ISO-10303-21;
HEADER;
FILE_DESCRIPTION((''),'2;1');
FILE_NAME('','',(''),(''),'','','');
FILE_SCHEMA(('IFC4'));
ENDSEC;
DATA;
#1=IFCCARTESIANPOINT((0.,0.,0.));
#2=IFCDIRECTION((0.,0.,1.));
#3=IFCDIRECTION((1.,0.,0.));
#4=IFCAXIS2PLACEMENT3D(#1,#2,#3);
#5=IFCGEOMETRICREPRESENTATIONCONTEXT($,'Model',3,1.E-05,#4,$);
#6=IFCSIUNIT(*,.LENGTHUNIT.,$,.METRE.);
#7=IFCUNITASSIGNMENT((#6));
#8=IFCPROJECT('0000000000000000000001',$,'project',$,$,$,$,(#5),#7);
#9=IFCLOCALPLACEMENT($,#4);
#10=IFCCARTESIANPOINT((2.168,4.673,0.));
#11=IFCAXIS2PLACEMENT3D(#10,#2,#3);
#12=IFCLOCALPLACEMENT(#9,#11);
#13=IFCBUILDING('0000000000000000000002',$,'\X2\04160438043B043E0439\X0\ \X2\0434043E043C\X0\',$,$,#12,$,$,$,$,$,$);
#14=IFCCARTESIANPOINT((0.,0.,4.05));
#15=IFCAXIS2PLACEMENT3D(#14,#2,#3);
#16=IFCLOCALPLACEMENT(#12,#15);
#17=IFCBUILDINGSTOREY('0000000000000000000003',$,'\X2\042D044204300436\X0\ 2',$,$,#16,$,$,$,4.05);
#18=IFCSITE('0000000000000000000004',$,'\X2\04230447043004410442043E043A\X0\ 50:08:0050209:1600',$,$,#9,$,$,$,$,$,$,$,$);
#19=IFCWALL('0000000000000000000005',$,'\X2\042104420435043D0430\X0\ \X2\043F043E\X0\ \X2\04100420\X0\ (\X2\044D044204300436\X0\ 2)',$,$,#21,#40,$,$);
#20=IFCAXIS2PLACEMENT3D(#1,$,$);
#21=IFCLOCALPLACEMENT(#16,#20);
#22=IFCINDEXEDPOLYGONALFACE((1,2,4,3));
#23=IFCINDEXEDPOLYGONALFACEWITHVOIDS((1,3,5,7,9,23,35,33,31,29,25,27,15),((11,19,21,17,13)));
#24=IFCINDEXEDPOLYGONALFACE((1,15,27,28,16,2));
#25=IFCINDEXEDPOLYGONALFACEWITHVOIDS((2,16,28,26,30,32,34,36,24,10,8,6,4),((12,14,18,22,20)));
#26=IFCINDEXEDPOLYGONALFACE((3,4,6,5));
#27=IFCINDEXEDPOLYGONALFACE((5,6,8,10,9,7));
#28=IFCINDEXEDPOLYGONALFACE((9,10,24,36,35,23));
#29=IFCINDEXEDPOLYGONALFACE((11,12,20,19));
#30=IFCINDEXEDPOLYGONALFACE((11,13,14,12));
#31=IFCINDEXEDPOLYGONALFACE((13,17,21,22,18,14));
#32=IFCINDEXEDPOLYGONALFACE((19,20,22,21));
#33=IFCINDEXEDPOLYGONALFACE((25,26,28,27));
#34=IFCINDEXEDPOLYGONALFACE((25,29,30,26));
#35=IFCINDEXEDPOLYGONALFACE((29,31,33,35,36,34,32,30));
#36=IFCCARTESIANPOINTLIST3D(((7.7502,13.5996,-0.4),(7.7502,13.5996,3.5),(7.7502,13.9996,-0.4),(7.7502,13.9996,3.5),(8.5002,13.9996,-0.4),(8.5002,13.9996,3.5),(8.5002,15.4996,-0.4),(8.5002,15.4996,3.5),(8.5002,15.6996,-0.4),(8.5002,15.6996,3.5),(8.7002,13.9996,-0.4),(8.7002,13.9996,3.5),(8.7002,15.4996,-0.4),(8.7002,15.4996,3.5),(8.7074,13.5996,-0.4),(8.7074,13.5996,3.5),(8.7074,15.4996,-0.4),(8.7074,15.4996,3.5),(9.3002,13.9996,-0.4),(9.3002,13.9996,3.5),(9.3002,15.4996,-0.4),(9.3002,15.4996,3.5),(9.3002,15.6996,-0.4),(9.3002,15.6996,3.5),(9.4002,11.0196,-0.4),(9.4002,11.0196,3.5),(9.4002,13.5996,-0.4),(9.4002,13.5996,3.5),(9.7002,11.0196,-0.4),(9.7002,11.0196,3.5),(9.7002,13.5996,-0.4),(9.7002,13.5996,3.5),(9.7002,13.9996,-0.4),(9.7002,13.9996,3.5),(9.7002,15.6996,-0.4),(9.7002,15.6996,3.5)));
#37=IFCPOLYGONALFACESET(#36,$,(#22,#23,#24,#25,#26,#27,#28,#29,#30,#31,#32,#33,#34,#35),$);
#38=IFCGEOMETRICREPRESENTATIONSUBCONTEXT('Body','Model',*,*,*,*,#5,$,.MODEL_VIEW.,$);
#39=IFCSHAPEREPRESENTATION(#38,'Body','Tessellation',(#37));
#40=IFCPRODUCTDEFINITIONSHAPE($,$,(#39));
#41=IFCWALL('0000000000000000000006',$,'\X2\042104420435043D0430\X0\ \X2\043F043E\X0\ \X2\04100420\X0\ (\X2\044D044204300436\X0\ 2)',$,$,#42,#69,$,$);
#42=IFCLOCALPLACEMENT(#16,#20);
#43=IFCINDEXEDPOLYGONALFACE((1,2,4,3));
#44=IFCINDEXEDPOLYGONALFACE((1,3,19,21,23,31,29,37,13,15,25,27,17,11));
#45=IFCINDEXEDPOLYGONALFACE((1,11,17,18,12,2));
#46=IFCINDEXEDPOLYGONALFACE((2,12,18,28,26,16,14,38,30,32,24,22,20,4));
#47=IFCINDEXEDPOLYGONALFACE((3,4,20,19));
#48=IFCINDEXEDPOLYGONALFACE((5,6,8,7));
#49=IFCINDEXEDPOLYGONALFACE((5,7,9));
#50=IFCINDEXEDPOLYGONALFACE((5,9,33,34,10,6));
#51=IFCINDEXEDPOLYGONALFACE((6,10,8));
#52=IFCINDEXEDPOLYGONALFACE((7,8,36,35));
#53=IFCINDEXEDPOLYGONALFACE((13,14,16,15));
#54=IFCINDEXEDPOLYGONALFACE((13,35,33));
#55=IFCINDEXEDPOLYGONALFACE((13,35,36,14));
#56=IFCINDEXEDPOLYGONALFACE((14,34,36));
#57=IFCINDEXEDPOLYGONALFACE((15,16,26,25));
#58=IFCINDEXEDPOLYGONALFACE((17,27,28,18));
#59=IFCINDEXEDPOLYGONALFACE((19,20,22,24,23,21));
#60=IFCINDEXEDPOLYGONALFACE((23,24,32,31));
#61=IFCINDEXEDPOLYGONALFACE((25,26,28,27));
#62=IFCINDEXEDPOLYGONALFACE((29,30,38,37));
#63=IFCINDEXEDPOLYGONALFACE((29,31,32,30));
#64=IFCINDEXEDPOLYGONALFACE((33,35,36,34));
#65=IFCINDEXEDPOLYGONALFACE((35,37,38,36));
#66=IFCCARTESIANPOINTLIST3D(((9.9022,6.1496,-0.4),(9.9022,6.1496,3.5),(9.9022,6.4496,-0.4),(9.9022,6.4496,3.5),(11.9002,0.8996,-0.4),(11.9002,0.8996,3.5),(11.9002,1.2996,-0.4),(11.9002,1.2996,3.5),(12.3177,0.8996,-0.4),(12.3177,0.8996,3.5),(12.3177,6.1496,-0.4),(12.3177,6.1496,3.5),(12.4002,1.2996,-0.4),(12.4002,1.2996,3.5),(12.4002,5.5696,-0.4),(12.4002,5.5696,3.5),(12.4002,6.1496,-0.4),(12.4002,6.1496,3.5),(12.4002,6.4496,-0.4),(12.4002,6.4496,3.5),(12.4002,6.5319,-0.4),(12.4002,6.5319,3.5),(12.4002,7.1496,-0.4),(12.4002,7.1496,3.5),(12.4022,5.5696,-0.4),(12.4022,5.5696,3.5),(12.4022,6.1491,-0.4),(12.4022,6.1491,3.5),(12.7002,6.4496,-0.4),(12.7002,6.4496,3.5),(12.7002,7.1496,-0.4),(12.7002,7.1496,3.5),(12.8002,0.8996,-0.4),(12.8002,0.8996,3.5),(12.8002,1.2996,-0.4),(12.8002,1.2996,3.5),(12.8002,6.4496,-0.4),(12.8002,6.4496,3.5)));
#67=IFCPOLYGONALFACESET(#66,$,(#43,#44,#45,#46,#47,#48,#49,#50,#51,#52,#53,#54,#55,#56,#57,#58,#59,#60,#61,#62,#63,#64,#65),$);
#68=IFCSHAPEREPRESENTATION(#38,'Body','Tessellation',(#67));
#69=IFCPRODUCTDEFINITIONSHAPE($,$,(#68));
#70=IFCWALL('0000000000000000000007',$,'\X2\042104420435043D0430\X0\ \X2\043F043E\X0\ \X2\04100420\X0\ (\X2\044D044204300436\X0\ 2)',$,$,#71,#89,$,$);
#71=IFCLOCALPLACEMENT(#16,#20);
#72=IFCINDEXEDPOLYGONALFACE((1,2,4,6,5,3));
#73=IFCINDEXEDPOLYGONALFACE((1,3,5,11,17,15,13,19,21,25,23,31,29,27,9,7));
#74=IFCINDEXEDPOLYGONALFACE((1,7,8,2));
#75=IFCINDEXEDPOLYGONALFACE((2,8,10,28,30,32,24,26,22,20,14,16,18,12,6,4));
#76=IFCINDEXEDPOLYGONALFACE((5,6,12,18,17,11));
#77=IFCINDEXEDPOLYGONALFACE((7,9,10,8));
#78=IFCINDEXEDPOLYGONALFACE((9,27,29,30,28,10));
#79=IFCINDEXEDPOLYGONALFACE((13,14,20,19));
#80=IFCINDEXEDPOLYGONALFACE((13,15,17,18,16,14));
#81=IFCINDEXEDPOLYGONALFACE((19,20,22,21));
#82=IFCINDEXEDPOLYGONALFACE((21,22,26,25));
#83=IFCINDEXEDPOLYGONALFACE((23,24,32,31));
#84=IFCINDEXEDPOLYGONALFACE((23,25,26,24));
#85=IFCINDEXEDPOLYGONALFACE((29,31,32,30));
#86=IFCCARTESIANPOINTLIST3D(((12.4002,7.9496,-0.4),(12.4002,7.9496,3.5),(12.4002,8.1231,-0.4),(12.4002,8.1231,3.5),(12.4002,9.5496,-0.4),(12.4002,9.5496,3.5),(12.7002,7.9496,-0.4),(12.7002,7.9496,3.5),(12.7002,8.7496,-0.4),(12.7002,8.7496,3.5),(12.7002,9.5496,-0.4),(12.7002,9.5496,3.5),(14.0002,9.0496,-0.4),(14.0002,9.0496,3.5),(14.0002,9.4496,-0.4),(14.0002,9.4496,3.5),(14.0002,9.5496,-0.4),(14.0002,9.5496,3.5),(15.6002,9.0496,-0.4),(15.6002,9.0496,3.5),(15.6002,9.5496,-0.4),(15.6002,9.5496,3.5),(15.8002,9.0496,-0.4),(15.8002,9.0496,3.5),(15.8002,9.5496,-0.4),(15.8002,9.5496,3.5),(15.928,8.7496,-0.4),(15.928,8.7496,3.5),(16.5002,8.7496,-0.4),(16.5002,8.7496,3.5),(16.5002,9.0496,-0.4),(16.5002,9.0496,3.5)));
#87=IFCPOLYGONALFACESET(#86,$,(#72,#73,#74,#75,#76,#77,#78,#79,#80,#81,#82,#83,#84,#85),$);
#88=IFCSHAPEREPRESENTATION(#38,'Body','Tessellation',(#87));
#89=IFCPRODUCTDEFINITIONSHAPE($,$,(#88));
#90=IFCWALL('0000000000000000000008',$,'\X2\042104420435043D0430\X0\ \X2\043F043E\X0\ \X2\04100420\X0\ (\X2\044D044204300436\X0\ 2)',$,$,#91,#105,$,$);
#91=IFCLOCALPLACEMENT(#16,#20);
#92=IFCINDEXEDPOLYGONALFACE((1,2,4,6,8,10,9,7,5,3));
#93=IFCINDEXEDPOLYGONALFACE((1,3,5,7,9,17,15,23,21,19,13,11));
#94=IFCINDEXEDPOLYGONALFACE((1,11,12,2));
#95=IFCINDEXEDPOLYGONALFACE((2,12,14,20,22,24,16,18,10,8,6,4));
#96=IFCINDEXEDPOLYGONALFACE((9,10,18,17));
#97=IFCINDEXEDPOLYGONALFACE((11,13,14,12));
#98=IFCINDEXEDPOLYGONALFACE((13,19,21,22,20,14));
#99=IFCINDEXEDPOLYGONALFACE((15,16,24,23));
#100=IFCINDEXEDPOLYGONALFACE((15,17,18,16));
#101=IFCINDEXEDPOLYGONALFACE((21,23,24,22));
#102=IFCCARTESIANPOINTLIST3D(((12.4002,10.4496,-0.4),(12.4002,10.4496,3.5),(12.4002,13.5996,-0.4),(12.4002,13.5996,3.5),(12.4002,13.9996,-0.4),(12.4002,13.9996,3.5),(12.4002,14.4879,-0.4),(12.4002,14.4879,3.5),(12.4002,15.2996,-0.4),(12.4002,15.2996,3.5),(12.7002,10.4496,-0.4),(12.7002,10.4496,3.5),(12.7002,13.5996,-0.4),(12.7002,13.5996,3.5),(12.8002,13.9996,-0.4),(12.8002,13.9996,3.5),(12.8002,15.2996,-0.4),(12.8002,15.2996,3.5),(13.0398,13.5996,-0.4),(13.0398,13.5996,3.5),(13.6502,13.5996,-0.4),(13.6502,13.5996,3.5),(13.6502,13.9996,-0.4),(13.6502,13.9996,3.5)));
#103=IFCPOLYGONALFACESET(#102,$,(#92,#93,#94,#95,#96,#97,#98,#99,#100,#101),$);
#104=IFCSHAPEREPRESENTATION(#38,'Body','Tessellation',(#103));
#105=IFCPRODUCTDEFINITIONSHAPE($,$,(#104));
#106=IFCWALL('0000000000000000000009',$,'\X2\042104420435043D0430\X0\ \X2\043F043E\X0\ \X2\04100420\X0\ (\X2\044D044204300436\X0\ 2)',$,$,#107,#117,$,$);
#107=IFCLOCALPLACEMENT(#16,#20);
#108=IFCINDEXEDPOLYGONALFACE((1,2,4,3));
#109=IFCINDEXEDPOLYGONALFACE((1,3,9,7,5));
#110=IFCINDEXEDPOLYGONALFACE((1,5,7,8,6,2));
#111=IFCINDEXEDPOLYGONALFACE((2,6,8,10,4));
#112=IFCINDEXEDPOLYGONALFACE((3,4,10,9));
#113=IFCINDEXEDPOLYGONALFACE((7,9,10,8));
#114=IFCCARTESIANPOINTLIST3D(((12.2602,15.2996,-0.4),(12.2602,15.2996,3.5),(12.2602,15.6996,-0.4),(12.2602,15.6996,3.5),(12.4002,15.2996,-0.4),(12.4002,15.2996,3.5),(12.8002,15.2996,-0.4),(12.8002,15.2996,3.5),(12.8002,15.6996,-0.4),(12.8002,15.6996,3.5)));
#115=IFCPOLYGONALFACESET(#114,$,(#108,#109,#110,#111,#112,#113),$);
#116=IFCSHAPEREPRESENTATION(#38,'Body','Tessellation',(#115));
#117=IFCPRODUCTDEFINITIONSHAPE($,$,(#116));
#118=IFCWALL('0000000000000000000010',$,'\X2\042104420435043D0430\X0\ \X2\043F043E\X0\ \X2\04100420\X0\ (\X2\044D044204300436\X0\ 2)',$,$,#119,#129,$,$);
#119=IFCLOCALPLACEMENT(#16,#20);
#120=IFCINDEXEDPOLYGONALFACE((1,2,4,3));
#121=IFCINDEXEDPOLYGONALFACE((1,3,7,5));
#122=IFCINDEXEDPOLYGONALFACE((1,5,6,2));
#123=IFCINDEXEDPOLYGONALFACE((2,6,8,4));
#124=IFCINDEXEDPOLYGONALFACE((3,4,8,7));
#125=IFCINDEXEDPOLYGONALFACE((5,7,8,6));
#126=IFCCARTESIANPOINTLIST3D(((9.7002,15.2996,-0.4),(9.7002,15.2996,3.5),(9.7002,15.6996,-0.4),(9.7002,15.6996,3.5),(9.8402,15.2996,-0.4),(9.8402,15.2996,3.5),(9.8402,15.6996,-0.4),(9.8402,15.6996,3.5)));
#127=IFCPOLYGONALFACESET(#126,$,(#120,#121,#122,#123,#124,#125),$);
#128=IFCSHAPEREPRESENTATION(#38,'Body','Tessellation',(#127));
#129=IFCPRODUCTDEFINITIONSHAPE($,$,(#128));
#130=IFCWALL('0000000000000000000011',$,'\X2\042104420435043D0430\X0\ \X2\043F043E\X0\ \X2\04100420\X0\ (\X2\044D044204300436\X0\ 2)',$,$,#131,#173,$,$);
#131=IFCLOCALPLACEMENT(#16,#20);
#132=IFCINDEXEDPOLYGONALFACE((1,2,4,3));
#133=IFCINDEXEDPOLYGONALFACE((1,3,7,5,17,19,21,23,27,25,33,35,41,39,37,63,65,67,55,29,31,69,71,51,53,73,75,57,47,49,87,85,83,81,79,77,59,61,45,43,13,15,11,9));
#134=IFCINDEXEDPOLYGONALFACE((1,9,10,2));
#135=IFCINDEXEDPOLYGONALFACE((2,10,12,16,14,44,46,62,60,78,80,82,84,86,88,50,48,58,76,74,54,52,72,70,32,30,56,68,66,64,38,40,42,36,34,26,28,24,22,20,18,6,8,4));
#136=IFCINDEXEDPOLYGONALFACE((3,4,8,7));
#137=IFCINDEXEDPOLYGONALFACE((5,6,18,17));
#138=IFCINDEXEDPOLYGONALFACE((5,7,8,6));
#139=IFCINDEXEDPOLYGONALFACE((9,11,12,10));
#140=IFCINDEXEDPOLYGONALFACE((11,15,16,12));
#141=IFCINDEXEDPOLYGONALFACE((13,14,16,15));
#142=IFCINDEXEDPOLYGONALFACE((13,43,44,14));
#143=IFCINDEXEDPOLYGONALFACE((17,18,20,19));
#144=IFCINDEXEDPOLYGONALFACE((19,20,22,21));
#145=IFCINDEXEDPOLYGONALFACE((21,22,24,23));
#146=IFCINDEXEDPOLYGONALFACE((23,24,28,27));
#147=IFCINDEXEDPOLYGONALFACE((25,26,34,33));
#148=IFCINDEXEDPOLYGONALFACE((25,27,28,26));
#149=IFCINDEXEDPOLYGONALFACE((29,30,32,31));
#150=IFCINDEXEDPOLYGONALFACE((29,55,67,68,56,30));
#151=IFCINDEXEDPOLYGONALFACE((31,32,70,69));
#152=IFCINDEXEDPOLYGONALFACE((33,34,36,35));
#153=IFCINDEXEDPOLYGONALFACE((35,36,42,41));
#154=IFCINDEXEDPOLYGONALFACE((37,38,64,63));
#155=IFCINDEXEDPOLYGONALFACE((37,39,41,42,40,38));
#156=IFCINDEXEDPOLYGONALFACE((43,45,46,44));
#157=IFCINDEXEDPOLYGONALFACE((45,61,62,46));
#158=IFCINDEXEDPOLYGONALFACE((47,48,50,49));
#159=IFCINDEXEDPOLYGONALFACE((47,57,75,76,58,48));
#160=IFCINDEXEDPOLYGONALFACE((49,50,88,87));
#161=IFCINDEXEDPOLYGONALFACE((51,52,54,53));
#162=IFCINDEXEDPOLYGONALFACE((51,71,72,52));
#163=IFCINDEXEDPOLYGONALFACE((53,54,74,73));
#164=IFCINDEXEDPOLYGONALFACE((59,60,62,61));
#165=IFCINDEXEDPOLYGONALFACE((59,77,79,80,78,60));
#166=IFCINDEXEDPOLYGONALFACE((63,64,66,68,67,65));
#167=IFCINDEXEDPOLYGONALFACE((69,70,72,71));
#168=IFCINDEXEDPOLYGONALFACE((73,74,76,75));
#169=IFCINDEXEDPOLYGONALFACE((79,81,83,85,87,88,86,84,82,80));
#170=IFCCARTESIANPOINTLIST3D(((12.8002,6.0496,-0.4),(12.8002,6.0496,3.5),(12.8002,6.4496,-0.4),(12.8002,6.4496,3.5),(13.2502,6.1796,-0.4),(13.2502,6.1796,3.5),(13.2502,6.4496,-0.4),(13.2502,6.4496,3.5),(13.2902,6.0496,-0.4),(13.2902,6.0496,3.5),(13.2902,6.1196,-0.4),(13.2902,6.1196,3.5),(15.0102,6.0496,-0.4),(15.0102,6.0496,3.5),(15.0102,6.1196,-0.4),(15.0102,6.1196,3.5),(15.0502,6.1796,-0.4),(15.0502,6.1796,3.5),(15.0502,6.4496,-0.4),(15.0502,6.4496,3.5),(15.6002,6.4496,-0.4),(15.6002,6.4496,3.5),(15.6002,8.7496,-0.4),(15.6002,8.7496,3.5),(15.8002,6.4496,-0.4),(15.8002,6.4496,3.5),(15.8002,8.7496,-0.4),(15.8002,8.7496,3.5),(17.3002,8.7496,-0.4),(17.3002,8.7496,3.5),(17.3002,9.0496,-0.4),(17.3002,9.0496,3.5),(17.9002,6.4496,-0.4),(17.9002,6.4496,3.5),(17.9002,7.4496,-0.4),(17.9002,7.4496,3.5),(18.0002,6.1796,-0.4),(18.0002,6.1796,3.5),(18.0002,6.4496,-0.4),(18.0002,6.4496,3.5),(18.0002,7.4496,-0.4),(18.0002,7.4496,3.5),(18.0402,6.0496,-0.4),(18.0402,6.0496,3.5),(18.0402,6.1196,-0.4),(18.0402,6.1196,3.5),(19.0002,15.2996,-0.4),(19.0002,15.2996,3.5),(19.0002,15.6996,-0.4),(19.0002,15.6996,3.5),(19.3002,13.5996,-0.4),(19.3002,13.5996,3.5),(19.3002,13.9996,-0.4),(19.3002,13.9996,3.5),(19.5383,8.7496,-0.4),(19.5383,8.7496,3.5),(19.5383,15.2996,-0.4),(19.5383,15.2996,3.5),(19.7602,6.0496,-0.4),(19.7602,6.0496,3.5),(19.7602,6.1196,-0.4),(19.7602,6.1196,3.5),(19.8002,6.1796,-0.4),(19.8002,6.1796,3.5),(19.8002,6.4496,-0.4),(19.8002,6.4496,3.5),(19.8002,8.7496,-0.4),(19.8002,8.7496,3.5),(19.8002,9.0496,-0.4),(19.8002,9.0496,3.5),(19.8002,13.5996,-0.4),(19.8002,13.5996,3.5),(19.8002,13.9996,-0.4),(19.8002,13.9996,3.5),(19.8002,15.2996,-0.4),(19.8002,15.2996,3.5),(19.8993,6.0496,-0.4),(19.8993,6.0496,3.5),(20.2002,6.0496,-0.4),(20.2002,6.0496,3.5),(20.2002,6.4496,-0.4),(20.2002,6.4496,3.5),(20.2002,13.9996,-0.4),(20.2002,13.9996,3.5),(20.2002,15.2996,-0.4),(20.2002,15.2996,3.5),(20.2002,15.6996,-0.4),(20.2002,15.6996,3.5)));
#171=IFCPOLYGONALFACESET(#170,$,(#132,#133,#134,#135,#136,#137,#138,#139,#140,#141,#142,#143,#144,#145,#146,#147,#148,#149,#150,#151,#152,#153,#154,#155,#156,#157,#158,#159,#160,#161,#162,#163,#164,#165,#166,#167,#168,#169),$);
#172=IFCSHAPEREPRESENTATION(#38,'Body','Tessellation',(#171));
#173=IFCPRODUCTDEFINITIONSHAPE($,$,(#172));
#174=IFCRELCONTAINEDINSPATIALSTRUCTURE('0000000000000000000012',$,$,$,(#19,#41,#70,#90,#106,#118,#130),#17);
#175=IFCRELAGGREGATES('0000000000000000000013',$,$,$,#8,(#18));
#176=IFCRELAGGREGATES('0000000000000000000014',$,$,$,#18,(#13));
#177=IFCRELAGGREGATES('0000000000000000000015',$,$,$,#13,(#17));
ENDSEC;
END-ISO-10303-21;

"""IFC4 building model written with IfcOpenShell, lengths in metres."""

from ifc_helpers import new_model, si_unit, frame, origin_with_axes, place, context, subcontext, project, spatial, polyline, outline, extrude, element, save


model = new_model("IFC4")

# Units and contexts
model_context = context("Model", 3, precision=1e-05, world=origin_with_axes())
body_context = subcontext(model_context, "Body", "Model", "MODEL_VIEW")
ifc_project = project(units=[si_unit("LENGTHUNIT", "METRE")], contexts=[model_context])

# Site, building, storey
site_placement = place(None, origin_with_axes())
site = spatial("IfcSite", under=ifc_project, at=site_placement, Name="Участок 50:08:0050209:1600")
building_placement = place(site_placement, frame((2.168, 4.673, 0.0), z_axis=(0.0, 0.0, 1.0), x_axis=(1.0, 0.0, 0.0)))
building = spatial("IfcBuilding", under=site, at=building_placement, Name="Жилой дом")
storey_placement = place(building_placement, frame((0.0, 0.0, 4.05), z_axis=(0.0, 0.0, 1.0), x_axis=(1.0, 0.0, 0.0)))
storey = spatial("IfcBuildingStorey", under=building, at=storey_placement, Name="Этаж 2", Elevation=4.05)

# Walls
wall_1_placement = place(storey_placement, frame((0.0, 0.0, -4.05), z_axis=(0.0, 0.0, 1.0), x_axis=(1.0, 0.0, 0.0)))
element("IfcWall", 1, at=wall_1_placement, inside=storey, Name="Стена по АР (этаж 2)", context=body_context, shape_type="SweptSolid", body=[
    extrude(outline(polyline([(8.5002, 15.4996), (8.5002, 15.6996), (9.3002, 15.6996), (9.3002, 15.6996), (9.7002, 15.6996), (9.7002, 13.9996), (9.7002, 13.5996), (9.7002, 13.5996), (9.7002, 11.0196), (9.4002, 11.0196), (9.4002, 13.5996), (8.7074, 13.5996), (7.7502, 13.5996), (7.7502, 13.9996), (8.5002, 13.9996), (8.5002, 15.4996)]), holes=[polyline([(8.7002, 13.9996), (9.3002, 13.9996), (9.3002, 15.4996), (8.7074, 15.4996), (8.7002, 15.4996), (8.7002, 13.9996)])]), frame((0.0, 0.0, 3.65), z_axis=(0.0, 0.0, 1.0), x_axis=(1.0, 0.0, 0.0)), (0.0, 0.0, 1.0), 3.9),
])
wall_2_placement = place(storey_placement, frame((0.0, 0.0, -4.05), z_axis=(0.0, 0.0, 1.0), x_axis=(1.0, 0.0, 0.0)))
element("IfcWall", 2, at=wall_2_placement, inside=storey, Name="Стена по АР (этаж 2)", context=body_context, shape_type="SweptSolid", body=[
    extrude(outline(polyline([(12.4002, 5.5696), (12.4022, 5.5696), (12.4022, 6.1491), (12.4002, 6.1496), (12.4002, 6.1496), (12.3177, 6.1496), (9.9022, 6.1496), (9.9022, 6.4496), (12.4002, 6.4496), (12.4002, 6.5319), (12.4002, 7.1496), (12.7002, 7.1496), (12.7002, 6.4496), (12.8002, 6.4496), (12.8002, 1.2996), (12.8002, 1.2996), (12.8002, 0.8996), (12.3177, 0.8996), (11.9002, 0.8996), (11.9002, 1.2996), (12.8002, 1.2996), (12.4002, 1.2996), (12.4002, 5.5696)])), frame((0.0, 0.0, 3.65), z_axis=(0.0, 0.0, 1.0), x_axis=(1.0, 0.0, 0.0)), (0.0, 0.0, 1.0), 3.9),
])
wall_3_placement = place(storey_placement, frame((0.0, 0.0, -4.05), z_axis=(0.0, 0.0, 1.0), x_axis=(1.0, 0.0, 0.0)))
element("IfcWall", 3, at=wall_3_placement, inside=storey, Name="Стена по АР (этаж 2)", context=body_context, shape_type="SweptSolid", body=[
    extrude(outline(polyline([(14.0002, 9.4496), (14.0002, 9.0496), (15.6002, 9.0496), (15.6002, 9.5496), (15.8002, 9.5496), (15.8002, 9.0496), (16.5002, 9.0496), (16.5002, 8.7496), (15.928, 8.7496), (12.7002, 8.7496), (12.7002, 9.0496), (13.9002, 9.0496), (13.9002, 9.4496), (13.0398, 9.4496), (12.7002, 9.4496), (12.7002, 7.9496), (12.4002, 7.9496), (12.4002, 8.1231), (12.4002, 9.5496), (12.7002, 9.5496), (14.0002, 9.5496), (14.0002, 9.4496)])), frame((0.0, 0.0, 3.65), z_axis=(0.0, 0.0, 1.0), x_axis=(1.0, 0.0, 0.0)), (0.0, 0.0, 1.0), 3.9),
])
wall_4_placement = place(storey_placement, frame((0.0, 0.0, -4.05), z_axis=(0.0, 0.0, 1.0), x_axis=(1.0, 0.0, 0.0)))
element("IfcWall", 4, at=wall_4_placement, inside=storey, Name="Стена по АР (этаж 2)", context=body_context, shape_type="SweptSolid", body=[
    extrude(outline(polyline([(12.4002, 15.2996), (12.8002, 15.2996), (12.8002, 13.9996), (13.6502, 13.9996), (13.6502, 13.5996), (13.0398, 13.5996), (12.7002, 13.5996), (12.7002, 10.4496), (12.4002, 10.4496), (12.4002, 13.5996), (12.4002, 13.9996), (12.4002, 14.4879), (12.4002, 15.2996)])), frame((0.0, 0.0, 3.65), z_axis=(0.0, 0.0, 1.0), x_axis=(1.0, 0.0, 0.0)), (0.0, 0.0, 1.0), 3.9),
])
wall_5_placement = place(storey_placement, frame((0.0, 0.0, -4.05), z_axis=(0.0, 0.0, 1.0), x_axis=(1.0, 0.0, 0.0)))
element("IfcWall", 5, at=wall_5_placement, inside=storey, Name="Стена по АР (этаж 2)", context=body_context, shape_type="SweptSolid", body=[
    extrude(outline(polyline([(12.2602, 15.2996), (12.2602, 15.6996), (12.8002, 15.6996), (12.8002, 15.2996), (12.4002, 15.2996), (12.2602, 15.2996)])), frame((0.0, 0.0, 3.65), z_axis=(0.0, 0.0, 1.0), x_axis=(1.0, 0.0, 0.0)), (0.0, 0.0, 1.0), 3.9),
])
wall_6_placement = place(storey_placement, frame((0.0, 0.0, -4.05), z_axis=(0.0, 0.0, 1.0), x_axis=(1.0, 0.0, 0.0)))
element("IfcWall", 6, at=wall_6_placement, inside=storey, Name="Стена по АР (этаж 2)", context=body_context, shape_type="SweptSolid", body=[
    extrude(outline(polyline([(9.7002, 15.6996), (9.8402, 15.6996), (9.8402, 15.2996), (9.7002, 15.2996), (9.7002, 15.6996)])), frame((0.0, 0.0, 3.65), z_axis=(0.0, 0.0, 1.0), x_axis=(1.0, 0.0, 0.0)), (0.0, 0.0, 1.0), 3.9),
])
wall_7_placement = place(storey_placement, frame((0.0, 0.0, -4.05), z_axis=(0.0, 0.0, 1.0), x_axis=(1.0, 0.0, 0.0)))
element("IfcWall", 7, at=wall_7_placement, inside=storey, Name="Стена по АР (этаж 2)", context=body_context, shape_type="SweptSolid", body=[
    extrude(outline(polyline([(15.0102, 6.0496), (15.0102, 6.1196), (13.2902, 6.1196), (13.2902, 6.0496), (12.8002, 6.0496), (12.8002, 6.4496), (13.2502, 6.4496), (13.2502, 6.1796), (15.0502, 6.1796), (15.0502, 6.4496), (15.6002, 6.4496), (15.6002, 8.7496), (15.8002, 8.7496), (15.8002, 6.4496), (17.9002, 6.4496), (17.9002, 7.4496), (18.0002, 7.4496), (18.0002, 6.4496), (18.0002, 6.1796), (19.8002, 6.1796), (19.8002, 6.4496), (19.8002, 8.7496), (19.5383, 8.7496), (17.3002, 8.7496), (17.3002, 9.0496), (19.8002, 9.0496), (19.8002, 13.5996), (19.3002, 13.5996), (19.3002, 13.9996), (19.8002, 13.9996), (19.8002, 13.9996), (19.8002, 15.2996), (19.5383, 15.2996), (19.0002, 15.2996), (19.0002, 15.6996), (20.2002, 15.6996), (20.2002, 15.2996), (20.2002, 13.9996), (20.2002, 6.4496), (20.2002, 6.4496), (20.2002, 6.0496), (19.8993, 6.0496), (19.7602, 6.0496), (19.7602, 6.1196), (18.0402, 6.1196), (18.0402, 6.0496), (15.0102, 6.0496)])), frame((0.0, 0.0, 3.65), z_axis=(0.0, 0.0, 1.0), x_axis=(1.0, 0.0, 0.0)), (0.0, 0.0, 1.0), 3.9),
])

save(model, "model.ifc")
